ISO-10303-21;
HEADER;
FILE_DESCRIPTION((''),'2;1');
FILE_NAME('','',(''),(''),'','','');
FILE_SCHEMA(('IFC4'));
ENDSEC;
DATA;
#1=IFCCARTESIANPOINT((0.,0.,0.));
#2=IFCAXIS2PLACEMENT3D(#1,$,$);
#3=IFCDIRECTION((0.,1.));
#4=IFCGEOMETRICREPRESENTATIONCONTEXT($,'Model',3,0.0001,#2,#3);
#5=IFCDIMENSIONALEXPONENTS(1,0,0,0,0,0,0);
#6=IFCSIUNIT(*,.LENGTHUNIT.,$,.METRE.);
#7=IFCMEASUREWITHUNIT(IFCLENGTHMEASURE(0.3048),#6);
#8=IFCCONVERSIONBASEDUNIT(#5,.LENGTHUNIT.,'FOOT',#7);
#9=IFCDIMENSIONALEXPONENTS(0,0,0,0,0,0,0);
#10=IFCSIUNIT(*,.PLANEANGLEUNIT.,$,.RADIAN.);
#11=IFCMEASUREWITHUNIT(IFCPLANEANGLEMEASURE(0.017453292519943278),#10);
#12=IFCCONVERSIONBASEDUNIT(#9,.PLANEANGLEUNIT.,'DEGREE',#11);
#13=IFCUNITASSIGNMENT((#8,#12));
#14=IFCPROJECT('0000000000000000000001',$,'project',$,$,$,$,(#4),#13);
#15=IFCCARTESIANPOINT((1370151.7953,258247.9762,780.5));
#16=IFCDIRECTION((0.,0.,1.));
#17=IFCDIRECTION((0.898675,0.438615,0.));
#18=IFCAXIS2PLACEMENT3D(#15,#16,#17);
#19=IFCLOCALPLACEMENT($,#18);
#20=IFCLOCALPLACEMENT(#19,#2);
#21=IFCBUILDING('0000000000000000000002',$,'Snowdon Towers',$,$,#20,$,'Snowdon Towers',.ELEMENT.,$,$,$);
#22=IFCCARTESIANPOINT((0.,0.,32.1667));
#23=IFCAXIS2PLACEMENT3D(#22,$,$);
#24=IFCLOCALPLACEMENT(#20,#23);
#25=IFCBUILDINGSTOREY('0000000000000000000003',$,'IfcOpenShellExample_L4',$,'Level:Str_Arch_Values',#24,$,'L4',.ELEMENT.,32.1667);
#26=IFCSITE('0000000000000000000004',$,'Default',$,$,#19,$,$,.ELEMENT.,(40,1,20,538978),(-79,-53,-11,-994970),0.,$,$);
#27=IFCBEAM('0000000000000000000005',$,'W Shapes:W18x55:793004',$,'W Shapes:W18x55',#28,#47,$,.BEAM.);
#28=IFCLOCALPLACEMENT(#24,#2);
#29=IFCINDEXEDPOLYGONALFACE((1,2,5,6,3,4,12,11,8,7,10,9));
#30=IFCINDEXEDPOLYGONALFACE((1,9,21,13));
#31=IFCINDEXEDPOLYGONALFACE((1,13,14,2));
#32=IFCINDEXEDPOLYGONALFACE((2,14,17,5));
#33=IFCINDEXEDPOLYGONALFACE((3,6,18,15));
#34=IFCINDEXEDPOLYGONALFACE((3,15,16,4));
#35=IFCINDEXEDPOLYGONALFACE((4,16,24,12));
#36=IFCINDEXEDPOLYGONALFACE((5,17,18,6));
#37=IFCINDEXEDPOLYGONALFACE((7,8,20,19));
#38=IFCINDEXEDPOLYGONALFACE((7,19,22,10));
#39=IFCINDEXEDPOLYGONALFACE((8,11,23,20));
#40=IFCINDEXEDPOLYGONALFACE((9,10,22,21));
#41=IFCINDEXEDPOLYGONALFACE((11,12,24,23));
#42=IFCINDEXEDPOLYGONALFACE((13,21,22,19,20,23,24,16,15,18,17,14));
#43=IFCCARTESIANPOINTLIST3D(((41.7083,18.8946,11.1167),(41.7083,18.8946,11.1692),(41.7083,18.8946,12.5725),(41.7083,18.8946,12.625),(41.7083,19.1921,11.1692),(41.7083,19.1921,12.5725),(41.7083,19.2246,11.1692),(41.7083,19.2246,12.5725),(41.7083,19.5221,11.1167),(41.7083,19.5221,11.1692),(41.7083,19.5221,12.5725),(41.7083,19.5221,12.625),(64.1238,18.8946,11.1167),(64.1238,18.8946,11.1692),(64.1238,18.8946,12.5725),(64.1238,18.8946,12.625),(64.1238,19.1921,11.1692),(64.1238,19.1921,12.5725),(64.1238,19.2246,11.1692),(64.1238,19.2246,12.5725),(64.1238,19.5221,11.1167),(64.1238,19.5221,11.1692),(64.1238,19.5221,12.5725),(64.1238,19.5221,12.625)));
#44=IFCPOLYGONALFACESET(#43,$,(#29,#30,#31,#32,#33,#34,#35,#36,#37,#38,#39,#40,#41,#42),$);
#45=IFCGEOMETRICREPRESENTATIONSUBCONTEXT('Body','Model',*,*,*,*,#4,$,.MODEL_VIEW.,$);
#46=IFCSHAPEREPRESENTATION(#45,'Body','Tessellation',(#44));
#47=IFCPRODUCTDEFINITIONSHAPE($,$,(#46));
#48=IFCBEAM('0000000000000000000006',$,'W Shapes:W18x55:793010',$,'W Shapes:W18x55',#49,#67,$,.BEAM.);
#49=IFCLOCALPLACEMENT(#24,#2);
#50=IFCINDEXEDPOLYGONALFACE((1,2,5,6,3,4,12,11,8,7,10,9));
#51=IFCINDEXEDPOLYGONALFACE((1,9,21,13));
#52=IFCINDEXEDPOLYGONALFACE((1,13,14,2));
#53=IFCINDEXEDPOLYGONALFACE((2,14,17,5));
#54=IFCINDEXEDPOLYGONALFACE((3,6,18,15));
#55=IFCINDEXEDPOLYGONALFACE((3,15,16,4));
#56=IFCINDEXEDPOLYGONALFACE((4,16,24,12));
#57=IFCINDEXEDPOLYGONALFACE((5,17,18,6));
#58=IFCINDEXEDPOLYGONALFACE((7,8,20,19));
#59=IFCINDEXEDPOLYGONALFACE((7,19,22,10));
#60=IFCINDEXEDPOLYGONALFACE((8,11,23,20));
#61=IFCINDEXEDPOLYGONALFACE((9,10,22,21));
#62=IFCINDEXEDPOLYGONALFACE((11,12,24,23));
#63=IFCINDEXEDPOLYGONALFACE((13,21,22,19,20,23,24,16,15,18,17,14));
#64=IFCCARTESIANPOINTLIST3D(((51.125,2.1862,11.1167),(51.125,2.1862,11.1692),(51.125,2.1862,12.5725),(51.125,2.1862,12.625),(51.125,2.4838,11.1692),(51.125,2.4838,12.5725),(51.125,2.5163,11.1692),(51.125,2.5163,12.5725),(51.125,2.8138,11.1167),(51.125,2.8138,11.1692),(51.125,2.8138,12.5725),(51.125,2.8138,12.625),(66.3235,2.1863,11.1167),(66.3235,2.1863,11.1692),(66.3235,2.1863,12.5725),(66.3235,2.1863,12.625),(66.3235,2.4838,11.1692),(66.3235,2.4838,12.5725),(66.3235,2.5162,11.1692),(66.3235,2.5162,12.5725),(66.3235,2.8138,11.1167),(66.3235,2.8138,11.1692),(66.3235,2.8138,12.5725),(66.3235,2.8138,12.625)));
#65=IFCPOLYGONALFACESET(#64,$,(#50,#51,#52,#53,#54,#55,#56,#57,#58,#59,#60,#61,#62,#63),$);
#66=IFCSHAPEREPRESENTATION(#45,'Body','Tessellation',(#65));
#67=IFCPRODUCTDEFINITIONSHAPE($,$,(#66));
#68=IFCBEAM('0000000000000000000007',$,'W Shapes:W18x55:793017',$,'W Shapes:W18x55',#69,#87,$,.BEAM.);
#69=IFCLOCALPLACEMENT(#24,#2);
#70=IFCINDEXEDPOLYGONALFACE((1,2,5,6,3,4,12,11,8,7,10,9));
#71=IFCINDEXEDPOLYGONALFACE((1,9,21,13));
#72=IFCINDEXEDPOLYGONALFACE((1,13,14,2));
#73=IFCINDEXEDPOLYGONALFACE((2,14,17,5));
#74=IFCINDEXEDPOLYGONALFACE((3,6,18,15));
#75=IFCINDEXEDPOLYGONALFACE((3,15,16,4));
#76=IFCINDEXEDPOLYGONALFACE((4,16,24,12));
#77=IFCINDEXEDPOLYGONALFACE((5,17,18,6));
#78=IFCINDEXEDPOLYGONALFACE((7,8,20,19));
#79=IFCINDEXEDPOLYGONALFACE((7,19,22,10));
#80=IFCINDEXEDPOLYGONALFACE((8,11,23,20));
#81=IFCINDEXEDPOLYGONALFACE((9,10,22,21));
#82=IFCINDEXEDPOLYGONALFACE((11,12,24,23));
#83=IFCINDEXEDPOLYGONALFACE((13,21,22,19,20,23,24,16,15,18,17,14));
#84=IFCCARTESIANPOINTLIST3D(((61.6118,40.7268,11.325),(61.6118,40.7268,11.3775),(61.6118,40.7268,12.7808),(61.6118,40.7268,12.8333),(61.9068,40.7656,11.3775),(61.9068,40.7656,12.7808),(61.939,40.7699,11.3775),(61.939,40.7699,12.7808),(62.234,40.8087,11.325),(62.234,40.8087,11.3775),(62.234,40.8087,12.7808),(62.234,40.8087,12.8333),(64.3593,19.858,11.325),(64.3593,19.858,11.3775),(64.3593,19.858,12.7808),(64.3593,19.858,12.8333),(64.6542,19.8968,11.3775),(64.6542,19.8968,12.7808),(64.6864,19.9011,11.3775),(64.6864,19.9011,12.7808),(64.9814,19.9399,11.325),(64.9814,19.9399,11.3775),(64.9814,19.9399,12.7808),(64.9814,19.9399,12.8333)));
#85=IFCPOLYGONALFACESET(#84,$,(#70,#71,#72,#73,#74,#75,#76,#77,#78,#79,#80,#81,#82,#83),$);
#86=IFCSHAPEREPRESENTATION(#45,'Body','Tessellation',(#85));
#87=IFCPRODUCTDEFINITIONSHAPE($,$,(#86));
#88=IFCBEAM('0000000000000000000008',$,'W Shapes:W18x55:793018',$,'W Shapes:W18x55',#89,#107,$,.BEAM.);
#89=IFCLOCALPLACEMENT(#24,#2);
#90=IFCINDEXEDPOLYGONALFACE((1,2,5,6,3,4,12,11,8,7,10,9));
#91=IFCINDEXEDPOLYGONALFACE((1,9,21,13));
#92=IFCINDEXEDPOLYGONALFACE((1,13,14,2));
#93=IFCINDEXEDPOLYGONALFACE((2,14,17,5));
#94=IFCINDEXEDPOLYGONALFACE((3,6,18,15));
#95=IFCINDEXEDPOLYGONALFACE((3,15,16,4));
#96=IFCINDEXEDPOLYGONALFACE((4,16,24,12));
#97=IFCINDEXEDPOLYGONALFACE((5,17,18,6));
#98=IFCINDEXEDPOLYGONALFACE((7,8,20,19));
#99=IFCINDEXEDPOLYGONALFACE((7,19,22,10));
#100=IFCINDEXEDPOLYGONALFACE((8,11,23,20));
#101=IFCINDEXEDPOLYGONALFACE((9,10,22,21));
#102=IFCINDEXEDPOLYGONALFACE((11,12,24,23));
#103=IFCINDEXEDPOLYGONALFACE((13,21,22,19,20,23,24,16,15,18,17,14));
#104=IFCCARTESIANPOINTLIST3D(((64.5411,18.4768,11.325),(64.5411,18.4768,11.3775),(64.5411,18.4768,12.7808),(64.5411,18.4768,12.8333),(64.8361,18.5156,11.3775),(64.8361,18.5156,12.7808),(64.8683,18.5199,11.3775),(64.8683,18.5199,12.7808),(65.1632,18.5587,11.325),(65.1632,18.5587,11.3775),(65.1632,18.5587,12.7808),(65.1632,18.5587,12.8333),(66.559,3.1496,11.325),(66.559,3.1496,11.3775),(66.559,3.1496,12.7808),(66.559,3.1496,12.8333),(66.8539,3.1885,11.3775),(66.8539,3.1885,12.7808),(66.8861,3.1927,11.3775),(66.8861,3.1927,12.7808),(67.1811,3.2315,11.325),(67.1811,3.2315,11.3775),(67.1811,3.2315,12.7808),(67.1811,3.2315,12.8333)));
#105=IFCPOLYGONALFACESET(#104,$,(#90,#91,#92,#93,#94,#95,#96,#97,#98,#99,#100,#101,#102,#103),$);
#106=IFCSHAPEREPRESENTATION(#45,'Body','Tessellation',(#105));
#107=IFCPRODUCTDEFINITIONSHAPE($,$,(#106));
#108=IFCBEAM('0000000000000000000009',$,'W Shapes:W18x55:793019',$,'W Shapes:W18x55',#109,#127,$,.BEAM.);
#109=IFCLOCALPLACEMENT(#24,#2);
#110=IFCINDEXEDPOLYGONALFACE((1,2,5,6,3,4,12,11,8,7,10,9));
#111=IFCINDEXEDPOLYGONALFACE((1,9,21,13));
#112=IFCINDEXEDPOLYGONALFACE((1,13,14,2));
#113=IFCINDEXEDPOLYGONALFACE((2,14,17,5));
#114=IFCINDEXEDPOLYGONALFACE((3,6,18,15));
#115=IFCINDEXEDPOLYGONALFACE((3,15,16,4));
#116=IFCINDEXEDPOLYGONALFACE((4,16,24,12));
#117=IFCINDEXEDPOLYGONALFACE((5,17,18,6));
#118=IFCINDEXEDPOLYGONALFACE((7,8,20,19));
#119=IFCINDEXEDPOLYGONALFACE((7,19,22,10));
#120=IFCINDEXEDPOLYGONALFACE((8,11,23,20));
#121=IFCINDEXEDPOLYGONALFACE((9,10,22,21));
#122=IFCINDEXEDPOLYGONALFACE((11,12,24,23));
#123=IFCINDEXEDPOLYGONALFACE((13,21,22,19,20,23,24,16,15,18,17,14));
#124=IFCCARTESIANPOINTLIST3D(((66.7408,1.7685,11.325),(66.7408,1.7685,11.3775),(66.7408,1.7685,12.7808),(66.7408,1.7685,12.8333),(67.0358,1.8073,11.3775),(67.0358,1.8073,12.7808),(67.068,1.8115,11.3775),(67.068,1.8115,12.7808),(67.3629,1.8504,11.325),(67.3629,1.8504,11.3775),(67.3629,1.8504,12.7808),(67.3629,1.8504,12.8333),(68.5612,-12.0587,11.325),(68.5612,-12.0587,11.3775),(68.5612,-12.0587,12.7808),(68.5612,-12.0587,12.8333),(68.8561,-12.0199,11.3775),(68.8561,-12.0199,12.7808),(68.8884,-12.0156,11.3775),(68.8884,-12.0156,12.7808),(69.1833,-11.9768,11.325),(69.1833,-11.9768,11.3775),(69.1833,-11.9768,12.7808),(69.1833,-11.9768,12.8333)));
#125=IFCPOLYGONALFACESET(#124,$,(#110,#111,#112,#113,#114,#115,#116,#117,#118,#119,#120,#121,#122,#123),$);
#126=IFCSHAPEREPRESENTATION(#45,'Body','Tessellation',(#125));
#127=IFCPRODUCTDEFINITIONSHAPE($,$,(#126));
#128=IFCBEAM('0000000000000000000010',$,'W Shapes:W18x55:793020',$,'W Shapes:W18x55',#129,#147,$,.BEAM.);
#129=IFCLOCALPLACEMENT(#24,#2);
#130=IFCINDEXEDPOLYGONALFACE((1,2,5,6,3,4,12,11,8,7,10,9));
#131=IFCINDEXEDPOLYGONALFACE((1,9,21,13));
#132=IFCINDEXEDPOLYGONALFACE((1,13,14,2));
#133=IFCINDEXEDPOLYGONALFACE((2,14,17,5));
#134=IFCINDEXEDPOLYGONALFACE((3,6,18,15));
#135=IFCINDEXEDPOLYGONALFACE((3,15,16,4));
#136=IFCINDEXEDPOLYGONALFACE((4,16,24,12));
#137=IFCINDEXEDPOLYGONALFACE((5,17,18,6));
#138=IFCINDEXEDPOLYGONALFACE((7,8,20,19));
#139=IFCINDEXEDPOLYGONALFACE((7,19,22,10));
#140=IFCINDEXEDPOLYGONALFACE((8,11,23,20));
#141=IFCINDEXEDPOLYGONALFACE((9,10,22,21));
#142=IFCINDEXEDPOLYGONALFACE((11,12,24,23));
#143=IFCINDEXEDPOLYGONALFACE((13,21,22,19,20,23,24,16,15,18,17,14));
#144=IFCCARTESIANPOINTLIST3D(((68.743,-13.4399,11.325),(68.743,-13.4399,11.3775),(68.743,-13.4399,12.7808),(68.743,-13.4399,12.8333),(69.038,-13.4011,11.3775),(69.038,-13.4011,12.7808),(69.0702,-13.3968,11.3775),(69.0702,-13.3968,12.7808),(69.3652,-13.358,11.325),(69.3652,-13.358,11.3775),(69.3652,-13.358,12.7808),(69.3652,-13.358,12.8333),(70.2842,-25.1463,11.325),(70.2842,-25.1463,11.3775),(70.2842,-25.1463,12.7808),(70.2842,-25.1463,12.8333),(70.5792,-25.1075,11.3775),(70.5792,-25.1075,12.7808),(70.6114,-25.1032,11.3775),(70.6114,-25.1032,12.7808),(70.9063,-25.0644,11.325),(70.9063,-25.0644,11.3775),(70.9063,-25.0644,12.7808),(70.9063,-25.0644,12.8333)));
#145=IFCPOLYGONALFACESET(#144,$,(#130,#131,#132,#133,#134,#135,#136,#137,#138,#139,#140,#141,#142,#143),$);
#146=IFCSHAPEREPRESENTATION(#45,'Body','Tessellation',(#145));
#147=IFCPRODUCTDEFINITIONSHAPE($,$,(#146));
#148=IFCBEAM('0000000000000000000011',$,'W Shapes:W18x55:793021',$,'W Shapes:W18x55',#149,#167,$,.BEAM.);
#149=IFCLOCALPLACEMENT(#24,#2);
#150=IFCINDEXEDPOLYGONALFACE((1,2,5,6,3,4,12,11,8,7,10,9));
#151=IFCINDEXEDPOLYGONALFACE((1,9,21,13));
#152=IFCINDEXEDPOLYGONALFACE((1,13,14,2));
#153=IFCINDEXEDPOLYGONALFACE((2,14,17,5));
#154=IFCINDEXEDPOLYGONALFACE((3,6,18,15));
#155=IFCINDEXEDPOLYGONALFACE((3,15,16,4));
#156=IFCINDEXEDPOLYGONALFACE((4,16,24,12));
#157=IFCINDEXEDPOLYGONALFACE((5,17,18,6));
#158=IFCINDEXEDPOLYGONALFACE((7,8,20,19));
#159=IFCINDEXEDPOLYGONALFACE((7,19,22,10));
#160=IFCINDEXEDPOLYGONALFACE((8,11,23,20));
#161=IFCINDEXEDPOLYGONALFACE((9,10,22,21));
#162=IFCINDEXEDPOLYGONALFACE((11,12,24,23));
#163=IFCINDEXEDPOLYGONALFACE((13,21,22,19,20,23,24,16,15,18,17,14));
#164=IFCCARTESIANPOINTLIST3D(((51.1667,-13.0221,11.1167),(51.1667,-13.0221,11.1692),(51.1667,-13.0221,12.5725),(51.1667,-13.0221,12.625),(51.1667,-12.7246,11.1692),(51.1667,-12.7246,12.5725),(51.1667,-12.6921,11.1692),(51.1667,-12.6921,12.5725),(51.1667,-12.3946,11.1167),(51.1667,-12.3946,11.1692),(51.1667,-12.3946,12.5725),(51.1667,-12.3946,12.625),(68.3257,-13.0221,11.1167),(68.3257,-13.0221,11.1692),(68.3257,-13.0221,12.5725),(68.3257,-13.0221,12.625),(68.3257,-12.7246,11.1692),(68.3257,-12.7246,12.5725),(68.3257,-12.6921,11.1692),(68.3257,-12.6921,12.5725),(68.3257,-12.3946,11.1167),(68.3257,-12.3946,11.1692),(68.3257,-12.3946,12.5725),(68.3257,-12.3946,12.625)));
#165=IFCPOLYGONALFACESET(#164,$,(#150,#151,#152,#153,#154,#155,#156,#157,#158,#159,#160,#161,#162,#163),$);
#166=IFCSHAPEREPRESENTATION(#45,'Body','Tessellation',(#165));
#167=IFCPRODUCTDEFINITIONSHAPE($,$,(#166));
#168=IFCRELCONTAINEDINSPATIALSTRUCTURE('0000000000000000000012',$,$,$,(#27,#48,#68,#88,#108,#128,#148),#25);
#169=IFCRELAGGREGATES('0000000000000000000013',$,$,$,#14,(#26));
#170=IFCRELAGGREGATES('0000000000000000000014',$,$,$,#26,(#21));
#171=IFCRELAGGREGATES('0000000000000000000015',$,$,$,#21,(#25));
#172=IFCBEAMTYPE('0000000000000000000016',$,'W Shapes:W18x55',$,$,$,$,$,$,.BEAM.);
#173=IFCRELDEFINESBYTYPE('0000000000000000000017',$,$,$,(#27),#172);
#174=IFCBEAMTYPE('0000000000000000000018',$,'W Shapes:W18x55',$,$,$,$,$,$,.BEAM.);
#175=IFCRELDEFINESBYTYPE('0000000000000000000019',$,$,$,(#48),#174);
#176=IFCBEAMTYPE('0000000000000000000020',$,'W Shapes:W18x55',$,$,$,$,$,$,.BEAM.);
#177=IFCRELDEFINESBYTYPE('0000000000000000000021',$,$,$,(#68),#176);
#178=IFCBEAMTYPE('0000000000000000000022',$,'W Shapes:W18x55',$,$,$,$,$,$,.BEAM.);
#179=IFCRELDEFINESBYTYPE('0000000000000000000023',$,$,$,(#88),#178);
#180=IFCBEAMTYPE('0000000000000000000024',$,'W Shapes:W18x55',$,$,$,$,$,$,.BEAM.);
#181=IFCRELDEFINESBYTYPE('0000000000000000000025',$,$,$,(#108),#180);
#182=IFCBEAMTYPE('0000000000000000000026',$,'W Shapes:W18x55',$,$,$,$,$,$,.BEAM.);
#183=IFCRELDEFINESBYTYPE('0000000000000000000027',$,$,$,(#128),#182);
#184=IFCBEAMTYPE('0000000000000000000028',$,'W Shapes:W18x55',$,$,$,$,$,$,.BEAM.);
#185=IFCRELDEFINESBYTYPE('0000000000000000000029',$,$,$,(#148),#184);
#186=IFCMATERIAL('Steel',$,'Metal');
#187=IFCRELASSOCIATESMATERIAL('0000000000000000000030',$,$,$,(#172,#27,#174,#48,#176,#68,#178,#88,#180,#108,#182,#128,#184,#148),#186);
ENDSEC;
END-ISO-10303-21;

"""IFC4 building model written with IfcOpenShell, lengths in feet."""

from ifc_helpers import new_model, entity, si_unit, converted_unit, direction, frame, origin, place, context, subcontext, project, spatial, indexed_curve, outline, extrude, source, transform, mapped, material, type_object, type_shapes, element, save


model = new_model("IFC4")

# Units and contexts
model_context = context("Model", 3, precision=0.0001, world=origin(), true_north=direction((0.0, 1.0)))
body_context = subcontext(model_context, "Body", "Model", "MODEL_VIEW")
ifc_project = project(units=[converted_unit("LENGTHUNIT", "FOOT", entity("IfcLengthMeasure", 0.3048), si_unit("LENGTHUNIT", "METRE"), dimensions=[1, 0, 0, 0, 0, 0, 0]), converted_unit("PLANEANGLEUNIT", "DEGREE", entity("IfcPlaneAngleMeasure", 0.017453292519943278), si_unit("PLANEANGLEUNIT", "RADIAN"), dimensions=[0, 0, 0, 0, 0, 0, 0])], contexts=[model_context])

# Site, building, storey
site_placement = place(None, frame((1370151.7953, 258247.9762, 780.5), z_axis=(0.0, 0.0, 1.0), x_axis=(0.898675, 0.438615, 0.0)))
site = spatial("IfcSite", under=ifc_project, at=site_placement, Name="Default", CompositionType="ELEMENT", RefLatitude=(40, 1, 20, 538978), RefLongitude=(-79, -53, -11, -994970), RefElevation=0.0)
building_placement = place(site_placement, origin())
building = spatial("IfcBuilding", under=site, at=building_placement, Name="Snowdon Towers", LongName="Snowdon Towers", CompositionType="ELEMENT")
storey_placement = place(building_placement, frame((0.0, 0.0, 32.1667)))
storey = spatial("IfcBuildingStorey", under=building, at=storey_placement, Name="IfcOpenShellExample_L4", ObjectType="Level:Str_Arch_Values", LongName="L4", CompositionType="ELEMENT", Elevation=32.1667)

# Shared definitions
ifc_material = material(Name="Steel", Category="Metal")

# Beams
beam_type_1 = type_object("IfcBeamType", Name="W Shapes:W18x55", PredefinedType="BEAM", material=ifc_material)
shared_shape_1 = source(origin(), body_context, "Body", "SweptSolid", [
    extrude(outline(indexed_curve([(-0.3138, -0.7017), (-0.3138, -0.7542), (0.3138, -0.7542), (0.3138, -0.7017), (0.0162, -0.7017), (0.0162, 0.7017), (0.3138, 0.7017), (0.3138, 0.7542), (-0.3137, 0.7542), (-0.3137, 0.7017), (-0.0163, 0.7017), (-0.0163, -0.7017), (-0.3138, -0.7017)], self_intersect=False)), frame((-11.5915, 0.0, 0.0), z_axis=(-1.0, 0.0, 0.0), x_axis=(0.0, -1.0, 0.0)), (0.0, 0.0, -1.0), 22.4154),
])
type_shapes(beam_type_1, [shared_shape_1])
beam_1_placement = place(storey_placement, frame((53.2998, 19.2083, 11.8708)))
element("IfcBeam", 1, at=beam_1_placement, inside=storey, type_object=beam_type_1, material=ifc_material, Name="W Shapes:W18x55:793004", ObjectType="W Shapes:W18x55", PredefinedType="BEAM", context=body_context, shape_type="MappedRepresentation", body=[
    mapped(shared_shape_1, transform((0.0, 0.0, 0.0), scale=1.0)),
])
beam_type_2 = type_object("IfcBeamType", Name="W Shapes:W18x55", PredefinedType="BEAM", material=ifc_material)
shared_shape_2 = source(origin(), body_context, "Body", "SweptSolid", [
    extrude(outline(indexed_curve([(-0.3138, -0.7017), (-0.3138, -0.7542), (0.3138, -0.7542), (0.3138, -0.7017), (0.0162, -0.7017), (0.0162, 0.7017), (0.3138, 0.7017), (0.3138, 0.7542), (-0.3137, 0.7542), (-0.3137, 0.7017), (-0.0163, 0.7017), (-0.0163, -0.7017), (-0.3138, -0.7017)], self_intersect=False)), frame((-8.2122, 0.0, 0.0), z_axis=(-1.0, 0.0, 0.0), x_axis=(0.0, -1.0, 0.0)), (0.0, 0.0, -1.0), 15.1985),
])
type_shapes(beam_type_2, [shared_shape_2])
beam_2_placement = place(storey_placement, frame((59.3372, 2.5, 11.8708)))
element("IfcBeam", 2, at=beam_2_placement, inside=storey, type_object=beam_type_2, material=ifc_material, Name="W Shapes:W18x55:793010", ObjectType="W Shapes:W18x55", PredefinedType="BEAM", context=body_context, shape_type="MappedRepresentation", body=[
    mapped(shared_shape_2, transform((0.0, 0.0, 0.0), scale=1.0)),
])
beam_type_3 = type_object("IfcBeamType", Name="W Shapes:W18x55", PredefinedType="BEAM", material=ifc_material)
shared_shape_3 = source(origin(), body_context, "Body", "SweptSolid", [
    extrude(outline(indexed_curve([(-0.3138, -0.7017), (-0.3138, -0.7542), (0.3138, -0.7542), (0.3138, -0.7017), (0.0162, -0.7017), (0.0162, 0.7017), (0.3138, 0.7017), (0.3138, 0.7542), (-0.3137, 0.7542), (-0.3137, 0.7017), (-0.0163, 0.7017), (-0.0163, -0.7017), (-0.3138, -0.7017)], self_intersect=False)), frame((-10.5172, 0.0, 0.0), z_axis=(-1.0, 0.0, 0.0), x_axis=(0.0, -1.0, 0.0)), (0.0, 0.0, -1.0), 21.0489),
])
type_shapes(beam_type_3, [shared_shape_3])
beam_3_placement = place(storey_placement, frame((63.2957, 30.3405, 12.0792), z_axis=(0.0, 0.0, 1.0), x_axis=(0.130526, -0.991445, 0.0)))
element("IfcBeam", 3, at=beam_3_placement, inside=storey, type_object=beam_type_3, material=ifc_material, Name="W Shapes:W18x55:793017", ObjectType="W Shapes:W18x55", PredefinedType="BEAM", context=body_context, shape_type="MappedRepresentation", body=[
    mapped(shared_shape_3, transform((0.0, 0.0, 0.0), scale=1.0)),
])
beam_type_4 = type_object("IfcBeamType", Name="W Shapes:W18x55", PredefinedType="BEAM", material=ifc_material)
shared_shape_4 = source(origin(), body_context, "Body", "SweptSolid", [
    extrude(outline(indexed_curve([(-0.3138, -0.7017), (-0.3138, -0.7542), (0.3138, -0.7542), (0.3138, -0.7017), (0.0162, -0.7017), (0.0162, 0.7017), (0.3138, 0.7017), (0.3138, 0.7542), (-0.3137, 0.7542), (-0.3137, 0.7017), (-0.0163, 0.7017), (-0.0163, -0.7017), (-0.3138, -0.7017)], self_intersect=False)), frame((-7.8065, 0.0, 0.0), z_axis=(-1.0, 0.0, 0.0), x_axis=(0.0, -1.0, 0.0)), (0.0, 0.0, -1.0), 15.4594),
])
type_shapes(beam_type_4, [shared_shape_4])
beam_4_placement = place(storey_placement, frame((65.8711, 10.778, 12.0792), z_axis=(0.0, 0.0, 1.0), x_axis=(0.130526, -0.991445, 0.0)))
element("IfcBeam", 4, at=beam_4_placement, inside=storey, type_object=beam_type_4, material=ifc_material, Name="W Shapes:W18x55:793018", ObjectType="W Shapes:W18x55", PredefinedType="BEAM", context=body_context, shape_type="MappedRepresentation", body=[
    mapped(shared_shape_4, transform((0.0, 0.0, 0.0), scale=1.0)),
])
beam_type_5 = type_object("IfcBeamType", Name="W Shapes:W18x55", PredefinedType="BEAM", material=ifc_material)
shared_shape_5 = source(origin(), body_context, "Body", "SweptSolid", [
    extrude(outline(indexed_curve([(-0.3138, -0.7017), (-0.3138, -0.7542), (0.3138, -0.7542), (0.3138, -0.7017), (0.0162, -0.7017), (0.0162, 0.7017), (0.3138, 0.7017), (0.3138, 0.7542), (-0.3137, 0.7542), (-0.3137, 0.7017), (-0.0163, 0.7017), (-0.0163, -0.7017), (-0.3138, -0.7017)], self_intersect=False)), frame((-7.05, 0.0, 0.0), z_axis=(-1.0, 0.0, 0.0), x_axis=(0.0, -1.0, 0.0)), (0.0, 0.0, -1.0), 13.9465),
])
type_shapes(beam_type_5, [shared_shape_5])
beam_5_placement = place(storey_placement, frame((67.9721, -5.1803, 12.0792), z_axis=(0.0, 0.0, 1.0), x_axis=(0.130526, -0.991445, 0.0)))
element("IfcBeam", 5, at=beam_5_placement, inside=storey, type_object=beam_type_5, material=ifc_material, Name="W Shapes:W18x55:793019", ObjectType="W Shapes:W18x55", PredefinedType="BEAM", context=body_context, shape_type="MappedRepresentation", body=[
    mapped(shared_shape_5, transform((0.0, 0.0, 0.0), scale=1.0)),
])
beam_type_6 = type_object("IfcBeamType", Name="W Shapes:W18x55", PredefinedType="BEAM", material=ifc_material)
shared_shape_6 = source(origin(), body_context, "Body", "SweptSolid", [
    extrude(outline(indexed_curve([(-0.3138, -0.7017), (-0.3138, -0.7542), (0.3138, -0.7542), (0.3138, -0.7017), (0.0162, -0.7017), (0.0162, 0.7017), (0.3138, 0.7017), (0.3138, 0.7542), (-0.3137, 0.7542), (-0.3137, 0.7017), (-0.0163, 0.7017), (-0.0163, -0.7017), (-0.3138, -0.7017)], self_intersect=False)), frame((-5.9188, 0.0, 0.0), z_axis=(-1.0, 0.0, 0.0), x_axis=(0.0, -1.0, 0.0)), (0.0, 0.0, -1.0), 11.8075),
])
type_shapes(beam_type_6, [shared_shape_6])
beam_6_placement = place(storey_placement, frame((69.8266, -19.2671, 12.0792), z_axis=(0.0, 0.0, 1.0), x_axis=(0.130526, -0.991445, 0.0)))
element("IfcBeam", 6, at=beam_6_placement, inside=storey, type_object=beam_type_6, material=ifc_material, Name="W Shapes:W18x55:793020", ObjectType="W Shapes:W18x55", PredefinedType="BEAM", context=body_context, shape_type="MappedRepresentation", body=[
    mapped(shared_shape_6, transform((0.0, 0.0, 0.0), scale=1.0)),
])
beam_type_7 = type_object("IfcBeamType", Name="W Shapes:W18x55", PredefinedType="BEAM", material=ifc_material)
shared_shape_7 = source(origin(), body_context, "Body", "SweptSolid", [
    extrude(outline(indexed_curve([(-0.3138, -0.7017), (-0.3138, -0.7542), (0.3138, -0.7542), (0.3138, -0.7017), (0.0162, -0.7017), (0.0162, 0.7017), (0.3138, 0.7017), (0.3138, 0.7542), (-0.3137, 0.7542), (-0.3137, 0.7017), (-0.0163, 0.7017), (-0.0163, -0.7017), (-0.3138, -0.7017)], self_intersect=False)), frame((-8.9216, 0.0, 0.0), z_axis=(-1.0, 0.0, 0.0), x_axis=(0.0, -1.0, 0.0)), (0.0, 0.0, -1.0), 17.159),
])
type_shapes(beam_type_7, [shared_shape_7])
beam_7_placement = place(storey_placement, frame((60.0883, -12.7083, 11.8708)))
element("IfcBeam", 7, at=beam_7_placement, inside=storey, type_object=beam_type_7, material=ifc_material, Name="W Shapes:W18x55:793021", ObjectType="W Shapes:W18x55", PredefinedType="BEAM", context=body_context, shape_type="MappedRepresentation", body=[
    mapped(shared_shape_7, transform((0.0, 0.0, 0.0), scale=1.0)),
])

save(model, "model.ifc")
